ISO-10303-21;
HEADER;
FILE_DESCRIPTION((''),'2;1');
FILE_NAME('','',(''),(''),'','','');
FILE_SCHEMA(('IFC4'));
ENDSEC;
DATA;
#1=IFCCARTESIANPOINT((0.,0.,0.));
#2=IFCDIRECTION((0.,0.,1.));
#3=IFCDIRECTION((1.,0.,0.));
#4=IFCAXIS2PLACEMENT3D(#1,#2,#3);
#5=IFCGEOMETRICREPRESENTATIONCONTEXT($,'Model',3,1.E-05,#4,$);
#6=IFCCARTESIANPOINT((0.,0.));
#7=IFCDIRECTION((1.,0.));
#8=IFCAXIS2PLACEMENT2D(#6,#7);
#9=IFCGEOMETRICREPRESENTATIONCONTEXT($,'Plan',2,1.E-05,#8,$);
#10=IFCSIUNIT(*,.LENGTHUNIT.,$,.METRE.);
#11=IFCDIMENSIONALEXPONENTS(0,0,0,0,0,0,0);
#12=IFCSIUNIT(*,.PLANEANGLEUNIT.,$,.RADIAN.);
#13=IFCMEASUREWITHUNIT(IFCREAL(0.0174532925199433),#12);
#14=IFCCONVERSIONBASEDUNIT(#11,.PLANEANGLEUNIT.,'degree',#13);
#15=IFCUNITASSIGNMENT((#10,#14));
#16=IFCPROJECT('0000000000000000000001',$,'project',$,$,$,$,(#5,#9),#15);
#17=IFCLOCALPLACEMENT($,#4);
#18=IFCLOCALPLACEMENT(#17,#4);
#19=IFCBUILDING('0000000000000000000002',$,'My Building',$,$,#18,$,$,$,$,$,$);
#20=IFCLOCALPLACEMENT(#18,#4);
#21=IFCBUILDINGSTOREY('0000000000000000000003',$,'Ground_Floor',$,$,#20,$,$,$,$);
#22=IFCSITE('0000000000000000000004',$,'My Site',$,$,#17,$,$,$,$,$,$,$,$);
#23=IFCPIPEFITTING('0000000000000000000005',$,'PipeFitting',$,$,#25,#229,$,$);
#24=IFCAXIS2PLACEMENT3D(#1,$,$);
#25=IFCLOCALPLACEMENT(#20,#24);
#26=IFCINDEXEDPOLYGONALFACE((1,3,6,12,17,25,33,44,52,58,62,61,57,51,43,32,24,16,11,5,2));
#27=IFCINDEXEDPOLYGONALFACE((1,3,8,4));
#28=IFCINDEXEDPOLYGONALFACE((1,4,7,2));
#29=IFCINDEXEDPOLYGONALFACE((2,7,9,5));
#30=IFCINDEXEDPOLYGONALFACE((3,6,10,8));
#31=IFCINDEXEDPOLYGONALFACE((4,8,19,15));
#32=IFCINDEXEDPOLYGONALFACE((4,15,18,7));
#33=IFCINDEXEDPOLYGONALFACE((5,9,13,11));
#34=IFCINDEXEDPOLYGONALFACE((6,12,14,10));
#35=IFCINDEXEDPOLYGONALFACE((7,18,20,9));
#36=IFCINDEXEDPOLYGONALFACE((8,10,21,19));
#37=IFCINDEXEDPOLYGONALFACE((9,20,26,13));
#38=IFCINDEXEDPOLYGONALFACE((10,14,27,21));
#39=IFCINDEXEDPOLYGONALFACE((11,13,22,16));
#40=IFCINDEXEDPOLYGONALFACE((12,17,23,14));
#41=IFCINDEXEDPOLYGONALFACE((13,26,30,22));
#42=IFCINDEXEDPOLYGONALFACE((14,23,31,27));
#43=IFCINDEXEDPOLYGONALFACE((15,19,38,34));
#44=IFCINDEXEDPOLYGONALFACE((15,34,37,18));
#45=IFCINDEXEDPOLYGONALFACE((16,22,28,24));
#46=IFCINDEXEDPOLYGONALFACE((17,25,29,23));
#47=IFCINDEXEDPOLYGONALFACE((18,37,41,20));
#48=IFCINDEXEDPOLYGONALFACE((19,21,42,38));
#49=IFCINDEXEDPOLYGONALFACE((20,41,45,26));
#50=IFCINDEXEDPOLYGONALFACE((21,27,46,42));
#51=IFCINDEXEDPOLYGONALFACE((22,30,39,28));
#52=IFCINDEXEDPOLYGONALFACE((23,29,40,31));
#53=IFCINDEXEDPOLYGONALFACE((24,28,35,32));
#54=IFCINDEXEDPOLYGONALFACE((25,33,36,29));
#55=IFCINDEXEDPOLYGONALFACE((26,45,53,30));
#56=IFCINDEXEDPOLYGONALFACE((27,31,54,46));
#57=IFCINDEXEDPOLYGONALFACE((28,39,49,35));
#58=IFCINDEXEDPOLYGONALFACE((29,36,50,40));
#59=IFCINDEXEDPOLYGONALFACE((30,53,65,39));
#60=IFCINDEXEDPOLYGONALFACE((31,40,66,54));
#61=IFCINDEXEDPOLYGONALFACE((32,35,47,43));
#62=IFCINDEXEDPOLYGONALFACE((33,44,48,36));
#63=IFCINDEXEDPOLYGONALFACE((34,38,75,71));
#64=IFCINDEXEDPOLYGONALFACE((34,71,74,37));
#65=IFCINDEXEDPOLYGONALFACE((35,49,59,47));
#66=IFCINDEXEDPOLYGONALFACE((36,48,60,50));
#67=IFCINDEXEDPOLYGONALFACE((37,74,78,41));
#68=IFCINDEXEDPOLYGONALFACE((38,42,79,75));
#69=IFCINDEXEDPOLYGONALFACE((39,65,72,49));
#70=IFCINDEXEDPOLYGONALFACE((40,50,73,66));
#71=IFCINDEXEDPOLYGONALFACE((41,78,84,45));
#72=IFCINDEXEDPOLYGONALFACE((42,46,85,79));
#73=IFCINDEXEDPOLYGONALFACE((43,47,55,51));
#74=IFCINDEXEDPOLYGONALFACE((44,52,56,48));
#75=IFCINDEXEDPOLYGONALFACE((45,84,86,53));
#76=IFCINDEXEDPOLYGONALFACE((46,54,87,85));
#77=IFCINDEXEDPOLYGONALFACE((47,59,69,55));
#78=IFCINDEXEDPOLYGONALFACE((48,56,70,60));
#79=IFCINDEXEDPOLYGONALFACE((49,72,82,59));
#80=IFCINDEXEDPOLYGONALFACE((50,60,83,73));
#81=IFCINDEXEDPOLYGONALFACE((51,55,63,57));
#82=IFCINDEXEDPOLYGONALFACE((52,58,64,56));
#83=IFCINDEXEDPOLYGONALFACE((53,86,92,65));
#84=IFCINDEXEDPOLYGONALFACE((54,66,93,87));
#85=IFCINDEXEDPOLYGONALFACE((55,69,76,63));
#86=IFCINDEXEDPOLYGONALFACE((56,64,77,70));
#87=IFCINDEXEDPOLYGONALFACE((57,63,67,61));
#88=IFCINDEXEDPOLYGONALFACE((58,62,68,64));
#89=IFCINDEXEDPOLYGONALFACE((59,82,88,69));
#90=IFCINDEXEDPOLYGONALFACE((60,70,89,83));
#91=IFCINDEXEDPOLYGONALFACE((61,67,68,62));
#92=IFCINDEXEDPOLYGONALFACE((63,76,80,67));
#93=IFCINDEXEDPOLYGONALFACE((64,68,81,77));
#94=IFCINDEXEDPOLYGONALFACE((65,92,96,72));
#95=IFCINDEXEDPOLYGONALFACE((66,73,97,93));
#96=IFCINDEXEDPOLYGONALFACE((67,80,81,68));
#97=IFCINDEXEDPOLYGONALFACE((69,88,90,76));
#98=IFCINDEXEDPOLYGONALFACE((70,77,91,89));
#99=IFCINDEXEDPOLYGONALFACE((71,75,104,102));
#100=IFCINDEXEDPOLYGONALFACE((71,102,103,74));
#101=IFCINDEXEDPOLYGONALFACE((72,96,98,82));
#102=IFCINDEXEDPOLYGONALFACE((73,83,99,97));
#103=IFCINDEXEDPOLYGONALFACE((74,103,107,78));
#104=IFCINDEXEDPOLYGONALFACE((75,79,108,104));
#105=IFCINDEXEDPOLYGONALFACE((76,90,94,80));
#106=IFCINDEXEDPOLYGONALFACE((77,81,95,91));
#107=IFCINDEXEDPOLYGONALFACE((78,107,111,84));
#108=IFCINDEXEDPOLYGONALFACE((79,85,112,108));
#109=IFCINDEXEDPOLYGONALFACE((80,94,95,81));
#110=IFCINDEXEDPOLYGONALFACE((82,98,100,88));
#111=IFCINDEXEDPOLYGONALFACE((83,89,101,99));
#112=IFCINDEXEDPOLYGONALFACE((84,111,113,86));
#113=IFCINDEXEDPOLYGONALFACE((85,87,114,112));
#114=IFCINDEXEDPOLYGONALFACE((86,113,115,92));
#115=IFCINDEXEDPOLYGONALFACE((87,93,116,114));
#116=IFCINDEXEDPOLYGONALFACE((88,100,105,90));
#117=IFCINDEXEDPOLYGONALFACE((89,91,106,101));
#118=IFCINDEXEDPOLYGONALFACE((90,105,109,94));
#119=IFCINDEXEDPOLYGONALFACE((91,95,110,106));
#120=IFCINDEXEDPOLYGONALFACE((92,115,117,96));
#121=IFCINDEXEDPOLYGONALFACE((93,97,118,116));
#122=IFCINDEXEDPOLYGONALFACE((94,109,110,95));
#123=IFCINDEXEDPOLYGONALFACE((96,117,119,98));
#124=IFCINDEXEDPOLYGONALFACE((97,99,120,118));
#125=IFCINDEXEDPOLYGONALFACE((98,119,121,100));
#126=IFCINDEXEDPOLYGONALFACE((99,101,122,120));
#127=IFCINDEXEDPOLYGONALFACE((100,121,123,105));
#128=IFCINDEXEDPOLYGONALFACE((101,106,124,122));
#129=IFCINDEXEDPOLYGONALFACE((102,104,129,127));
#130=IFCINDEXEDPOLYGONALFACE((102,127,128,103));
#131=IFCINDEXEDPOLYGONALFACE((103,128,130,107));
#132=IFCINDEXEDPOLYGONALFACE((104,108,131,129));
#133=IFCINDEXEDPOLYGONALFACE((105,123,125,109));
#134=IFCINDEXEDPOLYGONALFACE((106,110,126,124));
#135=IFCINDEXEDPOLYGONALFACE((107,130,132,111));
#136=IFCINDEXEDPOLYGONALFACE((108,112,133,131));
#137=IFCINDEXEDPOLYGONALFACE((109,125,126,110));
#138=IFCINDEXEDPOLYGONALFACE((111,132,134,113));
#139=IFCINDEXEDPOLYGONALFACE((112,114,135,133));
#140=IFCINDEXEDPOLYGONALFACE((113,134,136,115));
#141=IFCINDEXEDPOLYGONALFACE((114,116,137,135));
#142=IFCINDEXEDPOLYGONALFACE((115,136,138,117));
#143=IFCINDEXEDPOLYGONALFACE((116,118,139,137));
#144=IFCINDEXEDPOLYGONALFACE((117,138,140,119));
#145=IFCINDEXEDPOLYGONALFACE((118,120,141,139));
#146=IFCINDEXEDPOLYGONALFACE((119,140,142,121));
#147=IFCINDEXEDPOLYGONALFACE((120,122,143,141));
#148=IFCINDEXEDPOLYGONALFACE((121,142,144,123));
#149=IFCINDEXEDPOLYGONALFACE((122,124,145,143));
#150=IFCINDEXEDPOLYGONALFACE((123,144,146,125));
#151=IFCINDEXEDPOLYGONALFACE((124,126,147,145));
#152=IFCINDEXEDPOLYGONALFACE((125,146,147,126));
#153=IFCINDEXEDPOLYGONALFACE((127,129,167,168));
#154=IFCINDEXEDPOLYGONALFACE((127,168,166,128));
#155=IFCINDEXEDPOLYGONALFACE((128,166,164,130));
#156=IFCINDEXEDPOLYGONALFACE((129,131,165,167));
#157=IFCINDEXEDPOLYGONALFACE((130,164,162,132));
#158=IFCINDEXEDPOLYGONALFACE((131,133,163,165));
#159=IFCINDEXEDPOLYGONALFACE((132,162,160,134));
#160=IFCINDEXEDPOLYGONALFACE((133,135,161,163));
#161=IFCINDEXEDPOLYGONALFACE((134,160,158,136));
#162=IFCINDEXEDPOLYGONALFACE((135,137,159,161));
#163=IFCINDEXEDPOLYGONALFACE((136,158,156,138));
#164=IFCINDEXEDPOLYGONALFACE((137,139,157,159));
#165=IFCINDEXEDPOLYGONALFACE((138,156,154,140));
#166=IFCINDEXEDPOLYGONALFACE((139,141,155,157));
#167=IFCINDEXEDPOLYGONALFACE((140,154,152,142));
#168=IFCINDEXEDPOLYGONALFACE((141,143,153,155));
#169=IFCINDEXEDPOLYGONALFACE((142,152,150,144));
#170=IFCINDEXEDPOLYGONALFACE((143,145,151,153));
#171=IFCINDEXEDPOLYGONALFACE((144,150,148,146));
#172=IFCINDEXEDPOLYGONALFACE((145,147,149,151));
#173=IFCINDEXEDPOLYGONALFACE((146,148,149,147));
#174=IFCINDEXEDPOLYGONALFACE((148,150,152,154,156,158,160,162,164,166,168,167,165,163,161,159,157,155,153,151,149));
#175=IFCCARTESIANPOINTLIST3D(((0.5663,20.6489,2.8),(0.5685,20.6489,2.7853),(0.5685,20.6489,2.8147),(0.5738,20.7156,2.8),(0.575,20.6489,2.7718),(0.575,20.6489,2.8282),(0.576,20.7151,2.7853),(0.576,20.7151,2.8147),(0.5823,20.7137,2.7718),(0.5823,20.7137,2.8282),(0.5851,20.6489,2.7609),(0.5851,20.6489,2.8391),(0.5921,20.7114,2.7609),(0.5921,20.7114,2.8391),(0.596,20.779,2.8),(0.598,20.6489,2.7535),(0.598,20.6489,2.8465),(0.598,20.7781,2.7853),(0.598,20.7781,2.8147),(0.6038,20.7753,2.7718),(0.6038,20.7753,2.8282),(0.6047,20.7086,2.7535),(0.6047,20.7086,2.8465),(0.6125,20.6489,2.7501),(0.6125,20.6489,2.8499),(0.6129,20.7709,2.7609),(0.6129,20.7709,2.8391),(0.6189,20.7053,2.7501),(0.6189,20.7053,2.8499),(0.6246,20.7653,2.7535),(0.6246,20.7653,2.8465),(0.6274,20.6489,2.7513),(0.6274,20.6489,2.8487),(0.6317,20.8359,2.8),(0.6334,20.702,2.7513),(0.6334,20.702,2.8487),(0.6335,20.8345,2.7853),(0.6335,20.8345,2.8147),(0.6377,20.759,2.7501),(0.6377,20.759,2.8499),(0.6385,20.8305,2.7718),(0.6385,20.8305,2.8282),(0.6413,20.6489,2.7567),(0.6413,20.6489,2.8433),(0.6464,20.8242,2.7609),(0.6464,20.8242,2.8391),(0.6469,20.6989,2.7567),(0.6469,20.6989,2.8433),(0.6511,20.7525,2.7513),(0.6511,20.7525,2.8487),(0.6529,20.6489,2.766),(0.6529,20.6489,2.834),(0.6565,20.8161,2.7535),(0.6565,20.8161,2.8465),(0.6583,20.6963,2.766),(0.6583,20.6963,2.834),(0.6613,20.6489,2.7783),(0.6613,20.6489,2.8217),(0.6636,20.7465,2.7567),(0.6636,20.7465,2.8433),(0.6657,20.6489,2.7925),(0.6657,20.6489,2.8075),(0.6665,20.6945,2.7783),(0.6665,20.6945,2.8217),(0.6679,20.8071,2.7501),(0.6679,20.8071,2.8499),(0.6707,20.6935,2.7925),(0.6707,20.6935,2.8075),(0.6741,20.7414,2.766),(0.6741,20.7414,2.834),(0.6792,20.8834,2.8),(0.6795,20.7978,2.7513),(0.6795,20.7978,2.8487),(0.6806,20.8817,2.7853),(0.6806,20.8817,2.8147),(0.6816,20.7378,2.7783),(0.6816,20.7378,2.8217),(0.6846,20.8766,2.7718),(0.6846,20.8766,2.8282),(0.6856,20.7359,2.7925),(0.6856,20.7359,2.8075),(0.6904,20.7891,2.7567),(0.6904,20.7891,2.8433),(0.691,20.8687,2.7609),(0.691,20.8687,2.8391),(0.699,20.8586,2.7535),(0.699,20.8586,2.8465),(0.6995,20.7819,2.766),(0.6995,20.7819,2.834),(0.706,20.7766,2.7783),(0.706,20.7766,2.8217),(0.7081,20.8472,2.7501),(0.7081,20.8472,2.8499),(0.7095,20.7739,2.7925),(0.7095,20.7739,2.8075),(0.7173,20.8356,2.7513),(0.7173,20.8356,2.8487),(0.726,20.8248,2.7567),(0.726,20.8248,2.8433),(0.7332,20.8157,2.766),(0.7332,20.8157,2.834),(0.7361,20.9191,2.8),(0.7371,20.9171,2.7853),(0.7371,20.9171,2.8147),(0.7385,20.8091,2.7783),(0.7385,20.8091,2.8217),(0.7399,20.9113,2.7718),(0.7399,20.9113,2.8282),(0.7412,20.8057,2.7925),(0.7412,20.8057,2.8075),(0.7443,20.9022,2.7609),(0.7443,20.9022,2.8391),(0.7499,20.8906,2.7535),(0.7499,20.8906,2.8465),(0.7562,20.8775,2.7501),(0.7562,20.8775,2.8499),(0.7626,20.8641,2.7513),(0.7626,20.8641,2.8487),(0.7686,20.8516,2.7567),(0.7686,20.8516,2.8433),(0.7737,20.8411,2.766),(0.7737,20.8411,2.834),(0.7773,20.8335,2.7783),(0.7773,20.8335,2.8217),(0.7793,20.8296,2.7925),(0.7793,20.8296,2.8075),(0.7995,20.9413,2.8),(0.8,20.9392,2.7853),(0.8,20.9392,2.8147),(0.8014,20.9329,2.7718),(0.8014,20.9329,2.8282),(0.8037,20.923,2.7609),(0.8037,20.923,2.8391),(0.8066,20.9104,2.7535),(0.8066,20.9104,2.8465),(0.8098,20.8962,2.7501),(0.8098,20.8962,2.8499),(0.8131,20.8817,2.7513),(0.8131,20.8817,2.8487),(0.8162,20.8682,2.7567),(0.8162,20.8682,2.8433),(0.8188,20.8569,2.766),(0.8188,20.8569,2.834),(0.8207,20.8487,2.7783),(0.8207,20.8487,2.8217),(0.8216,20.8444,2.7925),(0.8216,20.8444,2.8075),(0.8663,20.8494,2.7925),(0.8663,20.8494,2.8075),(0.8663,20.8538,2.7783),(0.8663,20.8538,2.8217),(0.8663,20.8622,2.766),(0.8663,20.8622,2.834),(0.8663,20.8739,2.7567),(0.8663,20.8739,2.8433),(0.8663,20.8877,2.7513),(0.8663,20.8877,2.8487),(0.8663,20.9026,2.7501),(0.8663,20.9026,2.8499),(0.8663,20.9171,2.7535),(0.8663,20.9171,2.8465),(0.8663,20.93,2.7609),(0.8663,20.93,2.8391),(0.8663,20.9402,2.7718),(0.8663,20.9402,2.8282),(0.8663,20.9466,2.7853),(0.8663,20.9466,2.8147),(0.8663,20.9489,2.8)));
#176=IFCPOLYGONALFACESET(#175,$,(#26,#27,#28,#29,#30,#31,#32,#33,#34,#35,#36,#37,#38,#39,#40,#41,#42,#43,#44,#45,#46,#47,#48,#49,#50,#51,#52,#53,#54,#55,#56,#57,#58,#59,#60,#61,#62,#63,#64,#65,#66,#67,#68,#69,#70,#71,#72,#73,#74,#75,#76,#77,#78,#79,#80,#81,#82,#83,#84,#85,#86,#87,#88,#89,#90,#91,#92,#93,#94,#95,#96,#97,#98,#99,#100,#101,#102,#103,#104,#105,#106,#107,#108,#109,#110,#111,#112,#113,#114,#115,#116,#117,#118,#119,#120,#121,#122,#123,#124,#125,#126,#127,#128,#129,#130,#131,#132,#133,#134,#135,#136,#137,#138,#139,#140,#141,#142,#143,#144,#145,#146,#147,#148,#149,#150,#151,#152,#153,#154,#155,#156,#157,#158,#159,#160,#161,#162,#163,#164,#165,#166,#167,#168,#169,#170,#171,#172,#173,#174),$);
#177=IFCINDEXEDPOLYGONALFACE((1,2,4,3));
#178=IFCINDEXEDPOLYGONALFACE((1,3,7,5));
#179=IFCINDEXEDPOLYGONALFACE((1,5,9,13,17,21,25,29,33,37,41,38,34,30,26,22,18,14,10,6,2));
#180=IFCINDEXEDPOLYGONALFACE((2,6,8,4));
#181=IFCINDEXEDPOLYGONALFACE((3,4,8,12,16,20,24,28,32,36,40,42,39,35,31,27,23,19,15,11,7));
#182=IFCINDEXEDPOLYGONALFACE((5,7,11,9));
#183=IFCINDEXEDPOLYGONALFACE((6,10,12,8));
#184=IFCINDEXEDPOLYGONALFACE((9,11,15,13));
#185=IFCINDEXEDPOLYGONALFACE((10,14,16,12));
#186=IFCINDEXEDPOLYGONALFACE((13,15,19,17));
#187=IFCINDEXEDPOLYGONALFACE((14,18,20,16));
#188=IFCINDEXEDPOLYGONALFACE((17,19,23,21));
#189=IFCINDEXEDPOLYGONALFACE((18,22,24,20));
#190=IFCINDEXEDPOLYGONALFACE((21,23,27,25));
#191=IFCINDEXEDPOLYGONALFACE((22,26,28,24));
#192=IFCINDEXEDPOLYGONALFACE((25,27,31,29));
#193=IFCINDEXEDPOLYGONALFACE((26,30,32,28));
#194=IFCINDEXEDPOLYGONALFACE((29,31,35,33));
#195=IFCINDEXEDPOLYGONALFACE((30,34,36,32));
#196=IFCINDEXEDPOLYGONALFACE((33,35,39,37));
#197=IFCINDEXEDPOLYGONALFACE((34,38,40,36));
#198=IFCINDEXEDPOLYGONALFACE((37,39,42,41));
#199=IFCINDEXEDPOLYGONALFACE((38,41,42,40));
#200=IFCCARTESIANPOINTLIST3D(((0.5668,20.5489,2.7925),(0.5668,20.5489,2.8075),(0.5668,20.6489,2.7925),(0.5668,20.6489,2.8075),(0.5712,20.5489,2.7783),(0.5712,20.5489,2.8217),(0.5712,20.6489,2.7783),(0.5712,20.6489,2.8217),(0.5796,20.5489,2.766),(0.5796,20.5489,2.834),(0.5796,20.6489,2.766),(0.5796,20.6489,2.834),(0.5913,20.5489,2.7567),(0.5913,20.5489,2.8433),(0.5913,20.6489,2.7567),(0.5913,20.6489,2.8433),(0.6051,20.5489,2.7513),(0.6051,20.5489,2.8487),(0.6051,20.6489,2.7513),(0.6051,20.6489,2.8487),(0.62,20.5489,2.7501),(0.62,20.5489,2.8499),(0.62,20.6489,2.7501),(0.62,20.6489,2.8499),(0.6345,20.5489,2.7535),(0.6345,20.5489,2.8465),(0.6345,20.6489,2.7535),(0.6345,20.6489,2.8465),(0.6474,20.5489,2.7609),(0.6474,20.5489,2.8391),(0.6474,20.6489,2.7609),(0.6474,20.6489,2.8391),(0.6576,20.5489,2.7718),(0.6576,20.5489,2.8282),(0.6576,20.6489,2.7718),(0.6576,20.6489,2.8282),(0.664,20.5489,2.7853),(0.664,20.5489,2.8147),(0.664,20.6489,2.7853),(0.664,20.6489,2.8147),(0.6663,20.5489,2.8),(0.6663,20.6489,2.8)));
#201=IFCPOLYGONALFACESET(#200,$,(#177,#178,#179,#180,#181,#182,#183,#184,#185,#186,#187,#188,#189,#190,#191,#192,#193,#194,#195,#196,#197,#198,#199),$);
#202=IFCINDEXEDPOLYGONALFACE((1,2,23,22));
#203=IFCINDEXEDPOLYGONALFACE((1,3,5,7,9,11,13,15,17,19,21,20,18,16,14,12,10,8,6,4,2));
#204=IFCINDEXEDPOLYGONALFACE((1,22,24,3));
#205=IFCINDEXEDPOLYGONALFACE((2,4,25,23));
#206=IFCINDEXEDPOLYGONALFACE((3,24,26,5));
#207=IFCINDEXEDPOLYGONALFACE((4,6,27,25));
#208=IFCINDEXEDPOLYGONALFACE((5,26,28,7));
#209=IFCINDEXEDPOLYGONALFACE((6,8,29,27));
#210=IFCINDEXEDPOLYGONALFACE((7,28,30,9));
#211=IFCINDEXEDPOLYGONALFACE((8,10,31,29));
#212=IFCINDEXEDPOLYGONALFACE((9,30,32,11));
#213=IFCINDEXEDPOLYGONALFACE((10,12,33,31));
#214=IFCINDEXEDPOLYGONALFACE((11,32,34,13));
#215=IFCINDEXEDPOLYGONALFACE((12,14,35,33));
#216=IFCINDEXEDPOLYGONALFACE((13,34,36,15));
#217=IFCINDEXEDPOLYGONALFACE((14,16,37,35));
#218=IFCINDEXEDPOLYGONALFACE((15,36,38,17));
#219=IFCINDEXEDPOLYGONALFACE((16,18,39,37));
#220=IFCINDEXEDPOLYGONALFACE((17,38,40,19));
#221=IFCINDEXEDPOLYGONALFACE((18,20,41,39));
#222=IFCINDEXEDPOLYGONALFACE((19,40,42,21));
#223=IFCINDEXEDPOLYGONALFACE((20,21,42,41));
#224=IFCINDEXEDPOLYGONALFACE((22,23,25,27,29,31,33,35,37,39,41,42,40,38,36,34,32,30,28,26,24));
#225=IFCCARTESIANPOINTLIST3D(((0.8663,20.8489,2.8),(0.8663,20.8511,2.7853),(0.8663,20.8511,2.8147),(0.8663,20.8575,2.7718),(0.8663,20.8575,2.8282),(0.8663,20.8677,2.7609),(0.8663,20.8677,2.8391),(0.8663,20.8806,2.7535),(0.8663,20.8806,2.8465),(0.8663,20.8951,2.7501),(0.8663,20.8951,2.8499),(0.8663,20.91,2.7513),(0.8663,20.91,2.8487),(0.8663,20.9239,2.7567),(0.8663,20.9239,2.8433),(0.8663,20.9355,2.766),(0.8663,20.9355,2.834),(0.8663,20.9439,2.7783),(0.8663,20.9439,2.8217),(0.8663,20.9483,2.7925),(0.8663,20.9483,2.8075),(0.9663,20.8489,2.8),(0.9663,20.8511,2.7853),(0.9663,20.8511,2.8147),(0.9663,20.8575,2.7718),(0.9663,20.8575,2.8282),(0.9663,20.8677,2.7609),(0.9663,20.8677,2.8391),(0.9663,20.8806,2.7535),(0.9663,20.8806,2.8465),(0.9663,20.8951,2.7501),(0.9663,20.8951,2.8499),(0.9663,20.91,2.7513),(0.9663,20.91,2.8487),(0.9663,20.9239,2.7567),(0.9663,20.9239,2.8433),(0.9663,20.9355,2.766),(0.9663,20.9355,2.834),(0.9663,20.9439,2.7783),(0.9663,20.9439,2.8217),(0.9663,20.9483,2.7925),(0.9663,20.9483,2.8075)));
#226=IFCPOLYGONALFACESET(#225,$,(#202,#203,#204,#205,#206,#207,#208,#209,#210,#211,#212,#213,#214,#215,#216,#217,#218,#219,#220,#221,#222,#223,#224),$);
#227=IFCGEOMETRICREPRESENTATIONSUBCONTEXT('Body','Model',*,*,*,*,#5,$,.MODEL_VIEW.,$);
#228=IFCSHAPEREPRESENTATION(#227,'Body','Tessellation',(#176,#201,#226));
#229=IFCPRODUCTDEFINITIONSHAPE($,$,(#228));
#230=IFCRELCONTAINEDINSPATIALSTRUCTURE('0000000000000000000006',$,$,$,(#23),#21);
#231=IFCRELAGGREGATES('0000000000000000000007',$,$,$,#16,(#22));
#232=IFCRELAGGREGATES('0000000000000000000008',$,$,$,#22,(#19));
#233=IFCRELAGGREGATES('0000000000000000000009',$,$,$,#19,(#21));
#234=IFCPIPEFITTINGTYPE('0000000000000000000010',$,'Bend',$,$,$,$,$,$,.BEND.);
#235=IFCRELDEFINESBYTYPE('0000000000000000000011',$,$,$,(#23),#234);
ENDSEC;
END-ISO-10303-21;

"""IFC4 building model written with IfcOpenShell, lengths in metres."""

from ifc_helpers import new_model, entity, si_unit, converted_unit, frame, origin_with_axes, origin_2d_with_axis, place, context, subcontext, project, spatial, circle, extrude, source, transform, mapped, type_object, type_shapes, element, save


model = new_model("IFC4")

# Units and contexts
model_context = context("Model", 3, precision=1e-05, world=origin_with_axes())
plan_context = context("Plan", 2, precision=1e-05, world=origin_2d_with_axis())
body_context = subcontext(model_context, "Body", "Model", "MODEL_VIEW")
ifc_project = project(units=[si_unit("LENGTHUNIT", "METRE"), converted_unit("PLANEANGLEUNIT", "degree", entity("IfcReal", 0.0174532925199433), si_unit("PLANEANGLEUNIT", "RADIAN"), dimensions=[0, 0, 0, 0, 0, 0, 0])], contexts=[model_context, plan_context])

# Site, building, storey
site_placement = place(None, origin_with_axes())
site = spatial("IfcSite", under=ifc_project, at=site_placement, Name="My Site")
building_placement = place(site_placement, origin_with_axes())
building = spatial("IfcBuilding", under=site, at=building_placement, Name="My Building")
storey_placement = place(building_placement, origin_with_axes())
storey = spatial("IfcBuildingStorey", under=building, at=storey_placement, Name="Ground_Floor")

# Pipe fitting
pipe_fitting_type = type_object("IfcPipeFittingType", Name="Bend", PredefinedType="BEND")
shared_shape = source(origin_with_axes(), body_context, "Body", "SolidModel", [
    entity("IfcSweptDiskSolid", entity("IfcIndexedPolyCurve", entity("IfcCartesianPointList3D", [[0.0, 0.0, -0.1], [0.0732, 0.0, -0.2768], [0.25, 0.0, -0.35]]), [entity("IfcArcIndex", [1, 2, 3])]), 0.05),
    extrude(circle(Radius=0.05), origin_with_axes(), (0.0, 0.0, -1.0), 0.1),
    extrude(circle(Radius=0.05), frame((0.25, 0.0, -0.35), z_axis=(1.0, 0.0, 0.0), x_axis=(0.0, 0.0, 1.0)), (0.0, 0.0, 1.0), 0.1),
])
type_shapes(pipe_fitting_type, [shared_shape])
for number, where, z_axis, x_axis, name in (
    (1, (0.6163, 20.5489, 2.8), (0.0, -1.0, 0.0), (1.0, 0.0, 0.0), "PipeFitting"),
):
    element("IfcPipeFitting", number, at=place(storey_placement, frame(where, z_axis=z_axis, x_axis=x_axis)), inside=storey, type_object=pipe_fitting_type, Name=name, context=body_context, shape_type="MappedRepresentation", body=[
        mapped(shared_shape, transform((0.0, 0.0, 0.0), x_axis=(1.0, 0.0, 0.0), y_axis=(0.0, 1.0, 0.0), z_axis=(0.0, 0.0, 1.0), scale=1.0)),
    ])

save(model, "model.ifc")
